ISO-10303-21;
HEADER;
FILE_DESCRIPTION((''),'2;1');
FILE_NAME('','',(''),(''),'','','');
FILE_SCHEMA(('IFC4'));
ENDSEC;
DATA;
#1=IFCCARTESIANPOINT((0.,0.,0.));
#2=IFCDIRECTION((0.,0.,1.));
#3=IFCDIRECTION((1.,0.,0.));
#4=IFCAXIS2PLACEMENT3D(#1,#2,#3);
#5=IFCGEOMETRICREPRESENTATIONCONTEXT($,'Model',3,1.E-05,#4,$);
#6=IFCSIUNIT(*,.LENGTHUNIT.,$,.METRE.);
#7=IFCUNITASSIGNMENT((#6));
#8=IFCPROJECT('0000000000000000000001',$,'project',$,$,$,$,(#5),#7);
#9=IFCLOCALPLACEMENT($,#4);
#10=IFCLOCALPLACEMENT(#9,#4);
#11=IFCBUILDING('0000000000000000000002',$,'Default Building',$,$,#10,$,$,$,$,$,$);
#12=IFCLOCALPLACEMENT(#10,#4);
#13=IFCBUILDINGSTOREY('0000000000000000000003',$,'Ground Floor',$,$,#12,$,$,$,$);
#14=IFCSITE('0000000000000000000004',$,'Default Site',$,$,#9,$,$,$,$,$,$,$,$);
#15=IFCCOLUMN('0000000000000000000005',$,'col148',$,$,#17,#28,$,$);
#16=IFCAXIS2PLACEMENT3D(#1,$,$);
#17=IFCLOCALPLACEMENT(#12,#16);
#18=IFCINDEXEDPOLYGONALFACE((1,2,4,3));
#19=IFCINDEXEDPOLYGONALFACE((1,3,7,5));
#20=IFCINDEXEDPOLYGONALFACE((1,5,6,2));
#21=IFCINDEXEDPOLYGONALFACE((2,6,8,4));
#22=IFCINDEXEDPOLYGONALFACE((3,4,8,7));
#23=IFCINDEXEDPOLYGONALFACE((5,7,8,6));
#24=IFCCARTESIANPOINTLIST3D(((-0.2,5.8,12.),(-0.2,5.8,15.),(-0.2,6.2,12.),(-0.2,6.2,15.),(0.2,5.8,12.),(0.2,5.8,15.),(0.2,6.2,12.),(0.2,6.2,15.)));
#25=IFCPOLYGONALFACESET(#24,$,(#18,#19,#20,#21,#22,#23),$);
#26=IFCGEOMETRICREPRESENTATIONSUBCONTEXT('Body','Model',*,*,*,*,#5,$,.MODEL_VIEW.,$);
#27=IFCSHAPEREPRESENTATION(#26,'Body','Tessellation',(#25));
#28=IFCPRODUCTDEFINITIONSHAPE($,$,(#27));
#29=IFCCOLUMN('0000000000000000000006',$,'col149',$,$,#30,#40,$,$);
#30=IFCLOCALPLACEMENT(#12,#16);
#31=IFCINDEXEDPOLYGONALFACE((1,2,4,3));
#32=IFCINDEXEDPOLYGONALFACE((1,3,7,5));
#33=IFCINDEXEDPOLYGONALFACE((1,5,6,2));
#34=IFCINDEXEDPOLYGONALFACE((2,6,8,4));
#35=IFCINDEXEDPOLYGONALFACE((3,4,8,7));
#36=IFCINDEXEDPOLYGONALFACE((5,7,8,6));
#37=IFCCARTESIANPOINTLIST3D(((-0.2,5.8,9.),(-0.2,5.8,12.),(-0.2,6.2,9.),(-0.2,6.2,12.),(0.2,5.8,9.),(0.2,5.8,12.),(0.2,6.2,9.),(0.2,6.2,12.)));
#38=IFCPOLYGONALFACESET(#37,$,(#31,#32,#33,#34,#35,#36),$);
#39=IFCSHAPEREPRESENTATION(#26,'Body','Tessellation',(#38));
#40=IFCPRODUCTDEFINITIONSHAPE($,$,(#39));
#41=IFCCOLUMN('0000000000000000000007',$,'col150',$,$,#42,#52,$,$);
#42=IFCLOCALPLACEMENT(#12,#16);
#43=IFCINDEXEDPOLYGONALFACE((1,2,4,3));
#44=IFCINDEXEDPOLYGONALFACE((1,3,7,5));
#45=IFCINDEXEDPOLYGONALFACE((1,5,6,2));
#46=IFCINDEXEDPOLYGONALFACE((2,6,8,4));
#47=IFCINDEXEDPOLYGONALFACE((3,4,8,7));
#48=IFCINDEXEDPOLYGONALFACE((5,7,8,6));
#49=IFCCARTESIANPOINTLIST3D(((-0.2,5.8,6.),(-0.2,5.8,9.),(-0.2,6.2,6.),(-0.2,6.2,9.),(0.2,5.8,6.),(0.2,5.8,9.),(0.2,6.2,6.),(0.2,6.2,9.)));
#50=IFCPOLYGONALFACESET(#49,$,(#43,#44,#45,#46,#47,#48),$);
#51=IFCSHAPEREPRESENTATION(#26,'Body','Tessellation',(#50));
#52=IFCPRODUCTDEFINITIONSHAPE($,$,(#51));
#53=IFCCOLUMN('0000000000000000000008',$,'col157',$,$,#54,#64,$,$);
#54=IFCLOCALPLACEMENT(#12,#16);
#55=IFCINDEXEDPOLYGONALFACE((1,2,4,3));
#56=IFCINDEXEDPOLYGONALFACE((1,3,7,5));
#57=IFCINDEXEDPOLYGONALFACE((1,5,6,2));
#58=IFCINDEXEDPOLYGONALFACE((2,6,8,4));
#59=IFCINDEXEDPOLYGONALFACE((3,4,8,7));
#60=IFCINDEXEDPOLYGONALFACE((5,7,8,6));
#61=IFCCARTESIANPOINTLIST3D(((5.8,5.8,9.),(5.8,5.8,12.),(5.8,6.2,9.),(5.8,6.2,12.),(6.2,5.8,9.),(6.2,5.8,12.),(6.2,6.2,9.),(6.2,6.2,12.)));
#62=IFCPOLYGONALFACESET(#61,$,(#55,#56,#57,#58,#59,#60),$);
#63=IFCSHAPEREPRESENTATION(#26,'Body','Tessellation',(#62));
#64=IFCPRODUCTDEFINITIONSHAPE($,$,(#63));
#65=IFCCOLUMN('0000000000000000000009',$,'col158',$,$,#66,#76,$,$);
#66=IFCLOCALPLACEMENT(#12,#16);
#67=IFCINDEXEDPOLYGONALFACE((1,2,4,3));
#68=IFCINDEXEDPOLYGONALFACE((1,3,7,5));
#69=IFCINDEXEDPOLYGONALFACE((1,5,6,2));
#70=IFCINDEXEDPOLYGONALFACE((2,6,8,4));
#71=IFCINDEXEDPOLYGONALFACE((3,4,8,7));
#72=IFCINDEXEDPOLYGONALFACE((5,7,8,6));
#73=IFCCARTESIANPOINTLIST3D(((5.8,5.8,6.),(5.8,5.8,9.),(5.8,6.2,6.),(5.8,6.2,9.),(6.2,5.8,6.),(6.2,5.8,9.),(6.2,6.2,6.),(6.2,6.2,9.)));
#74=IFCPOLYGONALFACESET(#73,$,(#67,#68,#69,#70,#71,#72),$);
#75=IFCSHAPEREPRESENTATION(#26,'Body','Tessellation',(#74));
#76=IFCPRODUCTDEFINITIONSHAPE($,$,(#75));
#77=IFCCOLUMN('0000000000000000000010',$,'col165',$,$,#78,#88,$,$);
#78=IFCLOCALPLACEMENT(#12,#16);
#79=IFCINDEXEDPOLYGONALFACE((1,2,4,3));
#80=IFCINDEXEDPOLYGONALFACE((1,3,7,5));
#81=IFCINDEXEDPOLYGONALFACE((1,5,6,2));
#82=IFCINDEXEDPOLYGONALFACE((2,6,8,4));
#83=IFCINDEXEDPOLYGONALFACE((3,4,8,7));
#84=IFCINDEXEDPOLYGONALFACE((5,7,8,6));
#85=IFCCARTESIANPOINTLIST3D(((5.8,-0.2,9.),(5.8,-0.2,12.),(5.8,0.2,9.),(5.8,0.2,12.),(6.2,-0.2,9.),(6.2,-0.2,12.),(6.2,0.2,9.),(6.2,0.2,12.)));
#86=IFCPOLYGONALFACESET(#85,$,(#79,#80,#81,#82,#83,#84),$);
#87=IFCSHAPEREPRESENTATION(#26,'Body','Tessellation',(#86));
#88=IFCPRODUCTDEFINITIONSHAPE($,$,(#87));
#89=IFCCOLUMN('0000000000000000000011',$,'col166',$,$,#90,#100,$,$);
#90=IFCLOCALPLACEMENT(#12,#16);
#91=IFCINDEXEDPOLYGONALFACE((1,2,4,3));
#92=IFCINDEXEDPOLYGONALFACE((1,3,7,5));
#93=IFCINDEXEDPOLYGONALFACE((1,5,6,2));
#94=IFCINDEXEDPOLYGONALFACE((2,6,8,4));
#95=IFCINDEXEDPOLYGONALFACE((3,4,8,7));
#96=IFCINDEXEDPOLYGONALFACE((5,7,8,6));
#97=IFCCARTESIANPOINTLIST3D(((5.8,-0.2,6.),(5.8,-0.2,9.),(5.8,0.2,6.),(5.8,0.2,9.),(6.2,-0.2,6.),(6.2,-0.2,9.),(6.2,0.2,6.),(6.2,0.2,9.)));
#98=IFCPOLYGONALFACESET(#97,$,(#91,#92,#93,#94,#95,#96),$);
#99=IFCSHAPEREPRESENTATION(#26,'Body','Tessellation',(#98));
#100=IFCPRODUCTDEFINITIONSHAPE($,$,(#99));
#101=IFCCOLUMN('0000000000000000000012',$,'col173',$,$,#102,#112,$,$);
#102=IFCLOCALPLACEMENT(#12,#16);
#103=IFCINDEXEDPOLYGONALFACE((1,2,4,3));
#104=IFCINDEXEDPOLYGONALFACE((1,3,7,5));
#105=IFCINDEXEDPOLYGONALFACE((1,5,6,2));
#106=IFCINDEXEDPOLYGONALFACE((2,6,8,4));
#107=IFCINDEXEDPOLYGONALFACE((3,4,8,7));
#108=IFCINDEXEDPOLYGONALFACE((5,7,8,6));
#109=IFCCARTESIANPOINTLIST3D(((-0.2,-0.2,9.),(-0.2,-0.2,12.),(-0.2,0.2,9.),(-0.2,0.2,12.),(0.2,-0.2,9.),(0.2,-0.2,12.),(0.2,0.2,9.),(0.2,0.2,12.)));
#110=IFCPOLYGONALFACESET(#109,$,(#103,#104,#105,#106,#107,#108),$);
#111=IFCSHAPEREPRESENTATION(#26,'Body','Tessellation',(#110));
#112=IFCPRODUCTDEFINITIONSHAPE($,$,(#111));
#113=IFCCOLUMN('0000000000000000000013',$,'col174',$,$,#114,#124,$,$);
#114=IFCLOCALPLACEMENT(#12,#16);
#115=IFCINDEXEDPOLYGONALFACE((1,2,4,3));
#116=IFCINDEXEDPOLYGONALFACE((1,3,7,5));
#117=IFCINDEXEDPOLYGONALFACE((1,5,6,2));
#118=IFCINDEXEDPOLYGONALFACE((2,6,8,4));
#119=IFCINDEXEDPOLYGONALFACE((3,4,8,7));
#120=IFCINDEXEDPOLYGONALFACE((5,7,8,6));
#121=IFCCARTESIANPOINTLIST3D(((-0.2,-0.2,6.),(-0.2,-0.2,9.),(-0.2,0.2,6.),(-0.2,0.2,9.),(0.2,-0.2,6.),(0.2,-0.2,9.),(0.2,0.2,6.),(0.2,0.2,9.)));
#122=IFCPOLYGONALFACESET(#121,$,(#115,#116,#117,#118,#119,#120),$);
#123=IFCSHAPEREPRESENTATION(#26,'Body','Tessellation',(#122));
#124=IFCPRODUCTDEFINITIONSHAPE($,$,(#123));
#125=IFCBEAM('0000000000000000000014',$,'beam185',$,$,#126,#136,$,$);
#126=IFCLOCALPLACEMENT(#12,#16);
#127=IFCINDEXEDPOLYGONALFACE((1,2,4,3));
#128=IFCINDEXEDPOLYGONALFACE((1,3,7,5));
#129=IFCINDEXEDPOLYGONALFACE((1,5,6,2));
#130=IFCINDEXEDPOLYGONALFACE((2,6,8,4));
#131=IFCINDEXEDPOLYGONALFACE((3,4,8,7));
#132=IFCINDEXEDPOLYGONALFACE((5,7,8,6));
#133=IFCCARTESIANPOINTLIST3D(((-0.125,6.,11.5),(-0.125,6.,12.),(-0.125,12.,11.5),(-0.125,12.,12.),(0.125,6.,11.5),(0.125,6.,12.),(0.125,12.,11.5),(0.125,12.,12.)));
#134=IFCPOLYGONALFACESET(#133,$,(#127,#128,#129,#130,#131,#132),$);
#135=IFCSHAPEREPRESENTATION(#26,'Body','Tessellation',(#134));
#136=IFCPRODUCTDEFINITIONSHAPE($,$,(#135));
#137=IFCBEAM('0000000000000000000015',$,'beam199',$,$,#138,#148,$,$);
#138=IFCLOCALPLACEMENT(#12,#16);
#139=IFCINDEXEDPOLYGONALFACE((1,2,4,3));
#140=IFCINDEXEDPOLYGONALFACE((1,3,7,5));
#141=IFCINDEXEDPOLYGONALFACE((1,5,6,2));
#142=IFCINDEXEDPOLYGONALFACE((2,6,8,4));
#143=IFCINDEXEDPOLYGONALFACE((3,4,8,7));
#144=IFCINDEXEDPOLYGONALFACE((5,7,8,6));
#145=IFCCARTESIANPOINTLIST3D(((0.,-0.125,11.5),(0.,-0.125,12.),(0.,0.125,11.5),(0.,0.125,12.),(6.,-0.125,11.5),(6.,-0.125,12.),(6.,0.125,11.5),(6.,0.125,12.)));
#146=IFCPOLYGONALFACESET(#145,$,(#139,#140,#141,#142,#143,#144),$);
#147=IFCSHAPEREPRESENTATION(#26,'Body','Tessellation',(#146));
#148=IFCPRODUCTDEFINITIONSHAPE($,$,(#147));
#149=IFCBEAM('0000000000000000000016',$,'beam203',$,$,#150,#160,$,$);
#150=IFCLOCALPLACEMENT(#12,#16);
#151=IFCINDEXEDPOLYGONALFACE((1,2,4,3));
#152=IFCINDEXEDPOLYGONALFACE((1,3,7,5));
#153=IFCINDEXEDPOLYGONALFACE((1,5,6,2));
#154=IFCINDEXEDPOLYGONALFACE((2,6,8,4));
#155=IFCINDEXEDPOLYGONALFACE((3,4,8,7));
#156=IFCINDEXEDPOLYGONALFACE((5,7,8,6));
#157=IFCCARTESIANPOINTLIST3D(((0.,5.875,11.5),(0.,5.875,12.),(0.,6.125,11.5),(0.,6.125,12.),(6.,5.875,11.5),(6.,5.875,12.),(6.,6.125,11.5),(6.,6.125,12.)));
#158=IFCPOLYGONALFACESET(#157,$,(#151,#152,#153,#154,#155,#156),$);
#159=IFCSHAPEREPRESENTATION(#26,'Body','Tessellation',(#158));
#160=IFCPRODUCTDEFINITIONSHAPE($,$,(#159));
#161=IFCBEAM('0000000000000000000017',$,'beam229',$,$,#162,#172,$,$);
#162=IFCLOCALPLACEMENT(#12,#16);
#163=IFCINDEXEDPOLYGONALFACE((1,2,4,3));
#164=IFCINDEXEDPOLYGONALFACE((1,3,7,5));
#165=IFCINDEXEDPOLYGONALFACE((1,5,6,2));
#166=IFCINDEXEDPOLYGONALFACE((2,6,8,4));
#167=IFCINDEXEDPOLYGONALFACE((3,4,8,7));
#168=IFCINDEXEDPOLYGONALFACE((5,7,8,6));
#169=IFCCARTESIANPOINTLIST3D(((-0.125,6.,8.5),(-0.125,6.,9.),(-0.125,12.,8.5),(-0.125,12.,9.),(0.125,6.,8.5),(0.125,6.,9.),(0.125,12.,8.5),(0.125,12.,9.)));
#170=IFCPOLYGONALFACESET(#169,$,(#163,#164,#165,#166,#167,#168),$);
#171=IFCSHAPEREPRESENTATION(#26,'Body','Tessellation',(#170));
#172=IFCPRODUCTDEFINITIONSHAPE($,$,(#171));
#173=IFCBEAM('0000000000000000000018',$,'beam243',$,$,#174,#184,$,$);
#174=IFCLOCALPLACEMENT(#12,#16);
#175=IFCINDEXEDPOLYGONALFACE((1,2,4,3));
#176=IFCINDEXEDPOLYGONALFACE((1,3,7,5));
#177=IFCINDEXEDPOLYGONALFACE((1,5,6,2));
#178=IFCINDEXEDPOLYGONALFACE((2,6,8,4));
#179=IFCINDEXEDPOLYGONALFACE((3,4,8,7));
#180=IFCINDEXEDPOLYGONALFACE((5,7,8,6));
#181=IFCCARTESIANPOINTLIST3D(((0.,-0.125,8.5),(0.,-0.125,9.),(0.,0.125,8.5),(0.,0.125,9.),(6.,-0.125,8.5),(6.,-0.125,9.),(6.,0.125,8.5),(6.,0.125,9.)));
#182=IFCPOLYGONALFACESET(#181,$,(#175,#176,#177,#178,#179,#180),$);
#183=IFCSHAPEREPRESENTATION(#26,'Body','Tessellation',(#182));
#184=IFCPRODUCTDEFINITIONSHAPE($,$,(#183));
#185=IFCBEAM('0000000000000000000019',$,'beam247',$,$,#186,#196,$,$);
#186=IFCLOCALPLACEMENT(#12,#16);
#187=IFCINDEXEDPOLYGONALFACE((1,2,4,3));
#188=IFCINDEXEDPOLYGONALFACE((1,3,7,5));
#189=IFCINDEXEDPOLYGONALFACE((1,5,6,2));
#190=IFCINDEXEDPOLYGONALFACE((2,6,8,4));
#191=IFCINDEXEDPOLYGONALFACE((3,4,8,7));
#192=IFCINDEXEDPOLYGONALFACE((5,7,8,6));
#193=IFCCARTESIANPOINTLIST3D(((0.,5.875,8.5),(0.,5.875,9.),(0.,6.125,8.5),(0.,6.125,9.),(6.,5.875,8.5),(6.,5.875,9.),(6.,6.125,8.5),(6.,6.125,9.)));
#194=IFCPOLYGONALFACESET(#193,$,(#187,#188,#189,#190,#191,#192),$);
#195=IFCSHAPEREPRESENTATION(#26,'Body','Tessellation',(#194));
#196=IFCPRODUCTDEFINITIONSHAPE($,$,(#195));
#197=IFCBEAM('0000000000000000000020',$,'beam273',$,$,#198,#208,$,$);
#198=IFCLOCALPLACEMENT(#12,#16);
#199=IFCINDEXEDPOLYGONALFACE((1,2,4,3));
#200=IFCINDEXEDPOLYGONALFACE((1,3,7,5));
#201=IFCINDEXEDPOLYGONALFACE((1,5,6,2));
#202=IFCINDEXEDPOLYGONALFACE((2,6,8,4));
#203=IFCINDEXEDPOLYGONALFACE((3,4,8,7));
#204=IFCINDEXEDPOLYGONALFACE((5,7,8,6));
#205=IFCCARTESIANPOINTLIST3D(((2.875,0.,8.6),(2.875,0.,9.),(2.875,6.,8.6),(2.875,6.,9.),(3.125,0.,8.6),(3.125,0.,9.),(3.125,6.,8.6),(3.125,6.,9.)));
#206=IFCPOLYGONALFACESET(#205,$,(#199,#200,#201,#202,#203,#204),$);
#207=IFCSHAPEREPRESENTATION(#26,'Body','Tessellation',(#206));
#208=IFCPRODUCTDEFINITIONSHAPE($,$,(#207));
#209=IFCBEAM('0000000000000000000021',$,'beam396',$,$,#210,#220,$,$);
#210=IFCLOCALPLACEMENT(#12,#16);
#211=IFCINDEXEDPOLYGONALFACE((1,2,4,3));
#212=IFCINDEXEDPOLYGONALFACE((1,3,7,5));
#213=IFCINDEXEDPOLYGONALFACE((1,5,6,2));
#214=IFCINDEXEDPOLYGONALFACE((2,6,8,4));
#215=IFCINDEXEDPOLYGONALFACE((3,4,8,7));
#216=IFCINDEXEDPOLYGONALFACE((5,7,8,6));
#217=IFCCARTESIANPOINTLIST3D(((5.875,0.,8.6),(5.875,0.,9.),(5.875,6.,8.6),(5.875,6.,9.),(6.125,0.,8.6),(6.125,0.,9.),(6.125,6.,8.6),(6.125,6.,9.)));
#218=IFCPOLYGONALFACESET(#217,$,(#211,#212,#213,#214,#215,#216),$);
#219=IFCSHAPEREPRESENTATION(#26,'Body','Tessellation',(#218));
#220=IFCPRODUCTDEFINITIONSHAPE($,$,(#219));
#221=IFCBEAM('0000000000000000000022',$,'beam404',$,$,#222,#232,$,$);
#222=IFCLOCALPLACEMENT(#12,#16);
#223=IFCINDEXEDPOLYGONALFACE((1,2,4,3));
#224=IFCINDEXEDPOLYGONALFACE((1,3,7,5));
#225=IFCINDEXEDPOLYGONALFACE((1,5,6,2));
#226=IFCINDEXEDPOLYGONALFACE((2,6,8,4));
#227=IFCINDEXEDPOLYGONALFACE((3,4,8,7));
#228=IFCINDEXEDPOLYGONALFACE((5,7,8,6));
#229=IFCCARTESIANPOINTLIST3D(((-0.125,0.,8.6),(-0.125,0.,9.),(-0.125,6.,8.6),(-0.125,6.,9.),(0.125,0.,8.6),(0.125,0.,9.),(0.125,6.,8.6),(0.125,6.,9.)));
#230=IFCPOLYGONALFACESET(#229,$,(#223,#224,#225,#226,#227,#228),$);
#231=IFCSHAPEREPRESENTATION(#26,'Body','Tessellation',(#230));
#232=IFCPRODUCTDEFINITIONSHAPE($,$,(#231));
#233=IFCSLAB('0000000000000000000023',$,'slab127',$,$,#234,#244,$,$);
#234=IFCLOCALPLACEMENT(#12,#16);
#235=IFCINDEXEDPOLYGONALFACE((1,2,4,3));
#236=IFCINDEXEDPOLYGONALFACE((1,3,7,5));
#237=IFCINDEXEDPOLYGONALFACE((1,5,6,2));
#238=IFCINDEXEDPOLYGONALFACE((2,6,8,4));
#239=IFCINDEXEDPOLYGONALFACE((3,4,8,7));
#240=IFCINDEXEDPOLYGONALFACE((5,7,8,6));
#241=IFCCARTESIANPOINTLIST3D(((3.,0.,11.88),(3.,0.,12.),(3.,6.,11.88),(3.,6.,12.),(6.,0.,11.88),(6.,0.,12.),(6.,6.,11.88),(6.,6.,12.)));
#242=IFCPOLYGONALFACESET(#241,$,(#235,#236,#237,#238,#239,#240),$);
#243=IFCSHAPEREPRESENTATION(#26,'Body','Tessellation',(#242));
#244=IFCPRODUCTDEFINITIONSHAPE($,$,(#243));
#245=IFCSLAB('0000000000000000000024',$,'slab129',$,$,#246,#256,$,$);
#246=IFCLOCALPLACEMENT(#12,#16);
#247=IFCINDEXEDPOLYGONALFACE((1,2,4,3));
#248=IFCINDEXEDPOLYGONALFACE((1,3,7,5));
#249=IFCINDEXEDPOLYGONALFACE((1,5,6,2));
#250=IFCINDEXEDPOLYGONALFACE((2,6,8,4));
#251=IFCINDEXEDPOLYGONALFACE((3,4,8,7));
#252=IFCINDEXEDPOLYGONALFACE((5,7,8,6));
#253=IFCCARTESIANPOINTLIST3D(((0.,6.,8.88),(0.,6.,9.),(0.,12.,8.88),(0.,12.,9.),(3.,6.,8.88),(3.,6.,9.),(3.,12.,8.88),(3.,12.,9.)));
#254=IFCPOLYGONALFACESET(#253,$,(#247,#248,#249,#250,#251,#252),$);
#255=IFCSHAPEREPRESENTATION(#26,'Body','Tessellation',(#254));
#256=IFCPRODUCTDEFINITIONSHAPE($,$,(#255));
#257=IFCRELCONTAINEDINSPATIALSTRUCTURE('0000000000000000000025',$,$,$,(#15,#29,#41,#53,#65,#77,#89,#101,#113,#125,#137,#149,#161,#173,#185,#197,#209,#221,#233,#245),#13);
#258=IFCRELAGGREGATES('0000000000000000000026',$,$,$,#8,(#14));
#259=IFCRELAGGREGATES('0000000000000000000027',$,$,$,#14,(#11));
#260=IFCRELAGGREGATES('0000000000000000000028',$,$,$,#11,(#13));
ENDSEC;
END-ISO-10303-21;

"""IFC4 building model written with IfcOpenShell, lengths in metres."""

from ifc_helpers import new_model, si_unit, frame, origin_with_axes, place, context, subcontext, project, spatial, indexed_curve, outline, extrude, element, save


model = new_model("IFC4")

# Units and contexts
model_context = context("Model", 3, precision=1e-05, world=origin_with_axes())
body_context = subcontext(model_context, "Body", "Model", "MODEL_VIEW")
ifc_project = project(units=[si_unit("LENGTHUNIT", "METRE")], contexts=[model_context])

# Site, building, storey
site_placement = place(None, origin_with_axes())
site = spatial("IfcSite", under=ifc_project, at=site_placement, Name="Default Site")
building_placement = place(site_placement, origin_with_axes())
building = spatial("IfcBuilding", under=site, at=building_placement, Name="Default Building")
storey_placement = place(building_placement, origin_with_axes())
storey = spatial("IfcBuildingStorey", under=building, at=storey_placement, Name="Ground Floor")

# Columns
for number, where, z_axis, x_axis, name in (
    (1, (-0.2, 5.8, 12.0), (0.0, 0.0, 1.0), (1.0, 0.0, 0.0), "col148"),
    (2, (-0.2, 5.8, 9.0), (0.0, 0.0, 1.0), (1.0, 0.0, 0.0), "col149"),
    (3, (-0.2, 5.8, 6.0), (0.0, 0.0, 1.0), (1.0, 0.0, 0.0), "col150"),
    (4, (5.8, 5.8, 9.0), (0.0, 0.0, 1.0), (1.0, 0.0, 0.0), "col157"),
    (5, (5.8, 5.8, 6.0), (0.0, 0.0, 1.0), (1.0, 0.0, 0.0), "col158"),
    (6, (5.8, -0.2, 9.0), (0.0, 0.0, 1.0), (1.0, 0.0, 0.0), "col165"),
    (7, (5.8, -0.2, 6.0), (0.0, 0.0, 1.0), (1.0, 0.0, 0.0), "col166"),
    (8, (-0.2, -0.2, 9.0), (0.0, 0.0, 1.0), (1.0, 0.0, 0.0), "col173"),
    (9, (-0.2, -0.2, 6.0), (0.0, 0.0, 1.0), (1.0, 0.0, 0.0), "col174"),
):
    element("IfcColumn", number, at=place(storey_placement, frame(where, z_axis=z_axis, x_axis=x_axis)), inside=storey, Name=name, context=body_context, shape_type="SweptSolid", body=[
        extrude(outline(indexed_curve([(0.0, 0.0), (0.0, 0.4), (0.4, 0.4), (0.4, 0.0), (0.0, 0.0)], self_intersect=False)), origin_with_axes(), (0.0, 0.0, 1.0), 3.0),
    ])

# Beams
for number, where, z_axis, x_axis, name in (
    (10, (0.125, 6.0, 11.5), (0.0, 0.0, 1.0), (0.0, 1.0, 0.0), "beam185"),
    (11, (0.0, -0.125, 11.5), (0.0, 0.0, 1.0), (1.0, 0.0, 0.0), "beam199"),
    (12, (0.0, 5.875, 11.5), (0.0, 0.0, 1.0), (1.0, 0.0, 0.0), "beam203"),
    (13, (0.125, 6.0, 8.5), (0.0, 0.0, 1.0), (0.0, 1.0, 0.0), "beam229"),
    (14, (0.0, -0.125, 8.5), (0.0, 0.0, 1.0), (1.0, 0.0, 0.0), "beam243"),
    (15, (0.0, 5.875, 8.5), (0.0, 0.0, 1.0), (1.0, 0.0, 0.0), "beam247"),
):
    element("IfcBeam", number, at=place(storey_placement, frame(where, z_axis=z_axis, x_axis=x_axis)), inside=storey, Name=name, context=body_context, shape_type="SweptSolid", body=[
        extrude(outline(indexed_curve([(0.0, 0.0), (0.0, 0.25), (6.0, 0.25), (6.0, 0.0), (0.0, 0.0)], self_intersect=False)), origin_with_axes(), (0.0, 0.0, 1.0), 0.5),
    ])
for number, where, z_axis, x_axis, name in (
    (16, (2.875, 6.0, 8.6), (0.0, 0.0, 1.0), (0.0, -1.0, 0.0), "beam273"),
    (17, (5.875, 6.0, 8.6), (0.0, 0.0, 1.0), (0.0, -1.0, 0.0), "beam396"),
    (18, (-0.125, 6.0, 8.6), (0.0, 0.0, 1.0), (0.0, -1.0, 0.0), "beam404"),
):
    element("IfcBeam", number, at=place(storey_placement, frame(where, z_axis=z_axis, x_axis=x_axis)), inside=storey, Name=name, context=body_context, shape_type="SweptSolid", body=[
        extrude(outline(indexed_curve([(0.0, 0.0), (0.0, 0.25), (6.0, 0.25), (6.0, 0.0), (0.0, 0.0)], self_intersect=False)), origin_with_axes(), (0.0, 0.0, 1.0), 0.4),
    ])

# Slabs
for number, where, z_axis, x_axis, name in (
    (19, (3.0, 0.0, 11.88), (0.0, 0.0, 1.0), (1.0, 0.0, 0.0), "slab127"),
    (20, (0.0, 6.0, 8.88), (0.0, 0.0, 1.0), (1.0, 0.0, 0.0), "slab129"),
):
    element("IfcSlab", number, at=place(storey_placement, frame(where, z_axis=z_axis, x_axis=x_axis)), inside=storey, Name=name, context=body_context, shape_type="SweptSolid", body=[
        extrude(outline(indexed_curve([(0.0, 0.0), (0.0, 6.0), (3.0, 6.0), (3.0, 0.0), (0.0, 0.0)], self_intersect=False)), origin_with_axes(), (0.0, 0.0, 1.0), 0.12),
    ])

save(model, "model.ifc")
